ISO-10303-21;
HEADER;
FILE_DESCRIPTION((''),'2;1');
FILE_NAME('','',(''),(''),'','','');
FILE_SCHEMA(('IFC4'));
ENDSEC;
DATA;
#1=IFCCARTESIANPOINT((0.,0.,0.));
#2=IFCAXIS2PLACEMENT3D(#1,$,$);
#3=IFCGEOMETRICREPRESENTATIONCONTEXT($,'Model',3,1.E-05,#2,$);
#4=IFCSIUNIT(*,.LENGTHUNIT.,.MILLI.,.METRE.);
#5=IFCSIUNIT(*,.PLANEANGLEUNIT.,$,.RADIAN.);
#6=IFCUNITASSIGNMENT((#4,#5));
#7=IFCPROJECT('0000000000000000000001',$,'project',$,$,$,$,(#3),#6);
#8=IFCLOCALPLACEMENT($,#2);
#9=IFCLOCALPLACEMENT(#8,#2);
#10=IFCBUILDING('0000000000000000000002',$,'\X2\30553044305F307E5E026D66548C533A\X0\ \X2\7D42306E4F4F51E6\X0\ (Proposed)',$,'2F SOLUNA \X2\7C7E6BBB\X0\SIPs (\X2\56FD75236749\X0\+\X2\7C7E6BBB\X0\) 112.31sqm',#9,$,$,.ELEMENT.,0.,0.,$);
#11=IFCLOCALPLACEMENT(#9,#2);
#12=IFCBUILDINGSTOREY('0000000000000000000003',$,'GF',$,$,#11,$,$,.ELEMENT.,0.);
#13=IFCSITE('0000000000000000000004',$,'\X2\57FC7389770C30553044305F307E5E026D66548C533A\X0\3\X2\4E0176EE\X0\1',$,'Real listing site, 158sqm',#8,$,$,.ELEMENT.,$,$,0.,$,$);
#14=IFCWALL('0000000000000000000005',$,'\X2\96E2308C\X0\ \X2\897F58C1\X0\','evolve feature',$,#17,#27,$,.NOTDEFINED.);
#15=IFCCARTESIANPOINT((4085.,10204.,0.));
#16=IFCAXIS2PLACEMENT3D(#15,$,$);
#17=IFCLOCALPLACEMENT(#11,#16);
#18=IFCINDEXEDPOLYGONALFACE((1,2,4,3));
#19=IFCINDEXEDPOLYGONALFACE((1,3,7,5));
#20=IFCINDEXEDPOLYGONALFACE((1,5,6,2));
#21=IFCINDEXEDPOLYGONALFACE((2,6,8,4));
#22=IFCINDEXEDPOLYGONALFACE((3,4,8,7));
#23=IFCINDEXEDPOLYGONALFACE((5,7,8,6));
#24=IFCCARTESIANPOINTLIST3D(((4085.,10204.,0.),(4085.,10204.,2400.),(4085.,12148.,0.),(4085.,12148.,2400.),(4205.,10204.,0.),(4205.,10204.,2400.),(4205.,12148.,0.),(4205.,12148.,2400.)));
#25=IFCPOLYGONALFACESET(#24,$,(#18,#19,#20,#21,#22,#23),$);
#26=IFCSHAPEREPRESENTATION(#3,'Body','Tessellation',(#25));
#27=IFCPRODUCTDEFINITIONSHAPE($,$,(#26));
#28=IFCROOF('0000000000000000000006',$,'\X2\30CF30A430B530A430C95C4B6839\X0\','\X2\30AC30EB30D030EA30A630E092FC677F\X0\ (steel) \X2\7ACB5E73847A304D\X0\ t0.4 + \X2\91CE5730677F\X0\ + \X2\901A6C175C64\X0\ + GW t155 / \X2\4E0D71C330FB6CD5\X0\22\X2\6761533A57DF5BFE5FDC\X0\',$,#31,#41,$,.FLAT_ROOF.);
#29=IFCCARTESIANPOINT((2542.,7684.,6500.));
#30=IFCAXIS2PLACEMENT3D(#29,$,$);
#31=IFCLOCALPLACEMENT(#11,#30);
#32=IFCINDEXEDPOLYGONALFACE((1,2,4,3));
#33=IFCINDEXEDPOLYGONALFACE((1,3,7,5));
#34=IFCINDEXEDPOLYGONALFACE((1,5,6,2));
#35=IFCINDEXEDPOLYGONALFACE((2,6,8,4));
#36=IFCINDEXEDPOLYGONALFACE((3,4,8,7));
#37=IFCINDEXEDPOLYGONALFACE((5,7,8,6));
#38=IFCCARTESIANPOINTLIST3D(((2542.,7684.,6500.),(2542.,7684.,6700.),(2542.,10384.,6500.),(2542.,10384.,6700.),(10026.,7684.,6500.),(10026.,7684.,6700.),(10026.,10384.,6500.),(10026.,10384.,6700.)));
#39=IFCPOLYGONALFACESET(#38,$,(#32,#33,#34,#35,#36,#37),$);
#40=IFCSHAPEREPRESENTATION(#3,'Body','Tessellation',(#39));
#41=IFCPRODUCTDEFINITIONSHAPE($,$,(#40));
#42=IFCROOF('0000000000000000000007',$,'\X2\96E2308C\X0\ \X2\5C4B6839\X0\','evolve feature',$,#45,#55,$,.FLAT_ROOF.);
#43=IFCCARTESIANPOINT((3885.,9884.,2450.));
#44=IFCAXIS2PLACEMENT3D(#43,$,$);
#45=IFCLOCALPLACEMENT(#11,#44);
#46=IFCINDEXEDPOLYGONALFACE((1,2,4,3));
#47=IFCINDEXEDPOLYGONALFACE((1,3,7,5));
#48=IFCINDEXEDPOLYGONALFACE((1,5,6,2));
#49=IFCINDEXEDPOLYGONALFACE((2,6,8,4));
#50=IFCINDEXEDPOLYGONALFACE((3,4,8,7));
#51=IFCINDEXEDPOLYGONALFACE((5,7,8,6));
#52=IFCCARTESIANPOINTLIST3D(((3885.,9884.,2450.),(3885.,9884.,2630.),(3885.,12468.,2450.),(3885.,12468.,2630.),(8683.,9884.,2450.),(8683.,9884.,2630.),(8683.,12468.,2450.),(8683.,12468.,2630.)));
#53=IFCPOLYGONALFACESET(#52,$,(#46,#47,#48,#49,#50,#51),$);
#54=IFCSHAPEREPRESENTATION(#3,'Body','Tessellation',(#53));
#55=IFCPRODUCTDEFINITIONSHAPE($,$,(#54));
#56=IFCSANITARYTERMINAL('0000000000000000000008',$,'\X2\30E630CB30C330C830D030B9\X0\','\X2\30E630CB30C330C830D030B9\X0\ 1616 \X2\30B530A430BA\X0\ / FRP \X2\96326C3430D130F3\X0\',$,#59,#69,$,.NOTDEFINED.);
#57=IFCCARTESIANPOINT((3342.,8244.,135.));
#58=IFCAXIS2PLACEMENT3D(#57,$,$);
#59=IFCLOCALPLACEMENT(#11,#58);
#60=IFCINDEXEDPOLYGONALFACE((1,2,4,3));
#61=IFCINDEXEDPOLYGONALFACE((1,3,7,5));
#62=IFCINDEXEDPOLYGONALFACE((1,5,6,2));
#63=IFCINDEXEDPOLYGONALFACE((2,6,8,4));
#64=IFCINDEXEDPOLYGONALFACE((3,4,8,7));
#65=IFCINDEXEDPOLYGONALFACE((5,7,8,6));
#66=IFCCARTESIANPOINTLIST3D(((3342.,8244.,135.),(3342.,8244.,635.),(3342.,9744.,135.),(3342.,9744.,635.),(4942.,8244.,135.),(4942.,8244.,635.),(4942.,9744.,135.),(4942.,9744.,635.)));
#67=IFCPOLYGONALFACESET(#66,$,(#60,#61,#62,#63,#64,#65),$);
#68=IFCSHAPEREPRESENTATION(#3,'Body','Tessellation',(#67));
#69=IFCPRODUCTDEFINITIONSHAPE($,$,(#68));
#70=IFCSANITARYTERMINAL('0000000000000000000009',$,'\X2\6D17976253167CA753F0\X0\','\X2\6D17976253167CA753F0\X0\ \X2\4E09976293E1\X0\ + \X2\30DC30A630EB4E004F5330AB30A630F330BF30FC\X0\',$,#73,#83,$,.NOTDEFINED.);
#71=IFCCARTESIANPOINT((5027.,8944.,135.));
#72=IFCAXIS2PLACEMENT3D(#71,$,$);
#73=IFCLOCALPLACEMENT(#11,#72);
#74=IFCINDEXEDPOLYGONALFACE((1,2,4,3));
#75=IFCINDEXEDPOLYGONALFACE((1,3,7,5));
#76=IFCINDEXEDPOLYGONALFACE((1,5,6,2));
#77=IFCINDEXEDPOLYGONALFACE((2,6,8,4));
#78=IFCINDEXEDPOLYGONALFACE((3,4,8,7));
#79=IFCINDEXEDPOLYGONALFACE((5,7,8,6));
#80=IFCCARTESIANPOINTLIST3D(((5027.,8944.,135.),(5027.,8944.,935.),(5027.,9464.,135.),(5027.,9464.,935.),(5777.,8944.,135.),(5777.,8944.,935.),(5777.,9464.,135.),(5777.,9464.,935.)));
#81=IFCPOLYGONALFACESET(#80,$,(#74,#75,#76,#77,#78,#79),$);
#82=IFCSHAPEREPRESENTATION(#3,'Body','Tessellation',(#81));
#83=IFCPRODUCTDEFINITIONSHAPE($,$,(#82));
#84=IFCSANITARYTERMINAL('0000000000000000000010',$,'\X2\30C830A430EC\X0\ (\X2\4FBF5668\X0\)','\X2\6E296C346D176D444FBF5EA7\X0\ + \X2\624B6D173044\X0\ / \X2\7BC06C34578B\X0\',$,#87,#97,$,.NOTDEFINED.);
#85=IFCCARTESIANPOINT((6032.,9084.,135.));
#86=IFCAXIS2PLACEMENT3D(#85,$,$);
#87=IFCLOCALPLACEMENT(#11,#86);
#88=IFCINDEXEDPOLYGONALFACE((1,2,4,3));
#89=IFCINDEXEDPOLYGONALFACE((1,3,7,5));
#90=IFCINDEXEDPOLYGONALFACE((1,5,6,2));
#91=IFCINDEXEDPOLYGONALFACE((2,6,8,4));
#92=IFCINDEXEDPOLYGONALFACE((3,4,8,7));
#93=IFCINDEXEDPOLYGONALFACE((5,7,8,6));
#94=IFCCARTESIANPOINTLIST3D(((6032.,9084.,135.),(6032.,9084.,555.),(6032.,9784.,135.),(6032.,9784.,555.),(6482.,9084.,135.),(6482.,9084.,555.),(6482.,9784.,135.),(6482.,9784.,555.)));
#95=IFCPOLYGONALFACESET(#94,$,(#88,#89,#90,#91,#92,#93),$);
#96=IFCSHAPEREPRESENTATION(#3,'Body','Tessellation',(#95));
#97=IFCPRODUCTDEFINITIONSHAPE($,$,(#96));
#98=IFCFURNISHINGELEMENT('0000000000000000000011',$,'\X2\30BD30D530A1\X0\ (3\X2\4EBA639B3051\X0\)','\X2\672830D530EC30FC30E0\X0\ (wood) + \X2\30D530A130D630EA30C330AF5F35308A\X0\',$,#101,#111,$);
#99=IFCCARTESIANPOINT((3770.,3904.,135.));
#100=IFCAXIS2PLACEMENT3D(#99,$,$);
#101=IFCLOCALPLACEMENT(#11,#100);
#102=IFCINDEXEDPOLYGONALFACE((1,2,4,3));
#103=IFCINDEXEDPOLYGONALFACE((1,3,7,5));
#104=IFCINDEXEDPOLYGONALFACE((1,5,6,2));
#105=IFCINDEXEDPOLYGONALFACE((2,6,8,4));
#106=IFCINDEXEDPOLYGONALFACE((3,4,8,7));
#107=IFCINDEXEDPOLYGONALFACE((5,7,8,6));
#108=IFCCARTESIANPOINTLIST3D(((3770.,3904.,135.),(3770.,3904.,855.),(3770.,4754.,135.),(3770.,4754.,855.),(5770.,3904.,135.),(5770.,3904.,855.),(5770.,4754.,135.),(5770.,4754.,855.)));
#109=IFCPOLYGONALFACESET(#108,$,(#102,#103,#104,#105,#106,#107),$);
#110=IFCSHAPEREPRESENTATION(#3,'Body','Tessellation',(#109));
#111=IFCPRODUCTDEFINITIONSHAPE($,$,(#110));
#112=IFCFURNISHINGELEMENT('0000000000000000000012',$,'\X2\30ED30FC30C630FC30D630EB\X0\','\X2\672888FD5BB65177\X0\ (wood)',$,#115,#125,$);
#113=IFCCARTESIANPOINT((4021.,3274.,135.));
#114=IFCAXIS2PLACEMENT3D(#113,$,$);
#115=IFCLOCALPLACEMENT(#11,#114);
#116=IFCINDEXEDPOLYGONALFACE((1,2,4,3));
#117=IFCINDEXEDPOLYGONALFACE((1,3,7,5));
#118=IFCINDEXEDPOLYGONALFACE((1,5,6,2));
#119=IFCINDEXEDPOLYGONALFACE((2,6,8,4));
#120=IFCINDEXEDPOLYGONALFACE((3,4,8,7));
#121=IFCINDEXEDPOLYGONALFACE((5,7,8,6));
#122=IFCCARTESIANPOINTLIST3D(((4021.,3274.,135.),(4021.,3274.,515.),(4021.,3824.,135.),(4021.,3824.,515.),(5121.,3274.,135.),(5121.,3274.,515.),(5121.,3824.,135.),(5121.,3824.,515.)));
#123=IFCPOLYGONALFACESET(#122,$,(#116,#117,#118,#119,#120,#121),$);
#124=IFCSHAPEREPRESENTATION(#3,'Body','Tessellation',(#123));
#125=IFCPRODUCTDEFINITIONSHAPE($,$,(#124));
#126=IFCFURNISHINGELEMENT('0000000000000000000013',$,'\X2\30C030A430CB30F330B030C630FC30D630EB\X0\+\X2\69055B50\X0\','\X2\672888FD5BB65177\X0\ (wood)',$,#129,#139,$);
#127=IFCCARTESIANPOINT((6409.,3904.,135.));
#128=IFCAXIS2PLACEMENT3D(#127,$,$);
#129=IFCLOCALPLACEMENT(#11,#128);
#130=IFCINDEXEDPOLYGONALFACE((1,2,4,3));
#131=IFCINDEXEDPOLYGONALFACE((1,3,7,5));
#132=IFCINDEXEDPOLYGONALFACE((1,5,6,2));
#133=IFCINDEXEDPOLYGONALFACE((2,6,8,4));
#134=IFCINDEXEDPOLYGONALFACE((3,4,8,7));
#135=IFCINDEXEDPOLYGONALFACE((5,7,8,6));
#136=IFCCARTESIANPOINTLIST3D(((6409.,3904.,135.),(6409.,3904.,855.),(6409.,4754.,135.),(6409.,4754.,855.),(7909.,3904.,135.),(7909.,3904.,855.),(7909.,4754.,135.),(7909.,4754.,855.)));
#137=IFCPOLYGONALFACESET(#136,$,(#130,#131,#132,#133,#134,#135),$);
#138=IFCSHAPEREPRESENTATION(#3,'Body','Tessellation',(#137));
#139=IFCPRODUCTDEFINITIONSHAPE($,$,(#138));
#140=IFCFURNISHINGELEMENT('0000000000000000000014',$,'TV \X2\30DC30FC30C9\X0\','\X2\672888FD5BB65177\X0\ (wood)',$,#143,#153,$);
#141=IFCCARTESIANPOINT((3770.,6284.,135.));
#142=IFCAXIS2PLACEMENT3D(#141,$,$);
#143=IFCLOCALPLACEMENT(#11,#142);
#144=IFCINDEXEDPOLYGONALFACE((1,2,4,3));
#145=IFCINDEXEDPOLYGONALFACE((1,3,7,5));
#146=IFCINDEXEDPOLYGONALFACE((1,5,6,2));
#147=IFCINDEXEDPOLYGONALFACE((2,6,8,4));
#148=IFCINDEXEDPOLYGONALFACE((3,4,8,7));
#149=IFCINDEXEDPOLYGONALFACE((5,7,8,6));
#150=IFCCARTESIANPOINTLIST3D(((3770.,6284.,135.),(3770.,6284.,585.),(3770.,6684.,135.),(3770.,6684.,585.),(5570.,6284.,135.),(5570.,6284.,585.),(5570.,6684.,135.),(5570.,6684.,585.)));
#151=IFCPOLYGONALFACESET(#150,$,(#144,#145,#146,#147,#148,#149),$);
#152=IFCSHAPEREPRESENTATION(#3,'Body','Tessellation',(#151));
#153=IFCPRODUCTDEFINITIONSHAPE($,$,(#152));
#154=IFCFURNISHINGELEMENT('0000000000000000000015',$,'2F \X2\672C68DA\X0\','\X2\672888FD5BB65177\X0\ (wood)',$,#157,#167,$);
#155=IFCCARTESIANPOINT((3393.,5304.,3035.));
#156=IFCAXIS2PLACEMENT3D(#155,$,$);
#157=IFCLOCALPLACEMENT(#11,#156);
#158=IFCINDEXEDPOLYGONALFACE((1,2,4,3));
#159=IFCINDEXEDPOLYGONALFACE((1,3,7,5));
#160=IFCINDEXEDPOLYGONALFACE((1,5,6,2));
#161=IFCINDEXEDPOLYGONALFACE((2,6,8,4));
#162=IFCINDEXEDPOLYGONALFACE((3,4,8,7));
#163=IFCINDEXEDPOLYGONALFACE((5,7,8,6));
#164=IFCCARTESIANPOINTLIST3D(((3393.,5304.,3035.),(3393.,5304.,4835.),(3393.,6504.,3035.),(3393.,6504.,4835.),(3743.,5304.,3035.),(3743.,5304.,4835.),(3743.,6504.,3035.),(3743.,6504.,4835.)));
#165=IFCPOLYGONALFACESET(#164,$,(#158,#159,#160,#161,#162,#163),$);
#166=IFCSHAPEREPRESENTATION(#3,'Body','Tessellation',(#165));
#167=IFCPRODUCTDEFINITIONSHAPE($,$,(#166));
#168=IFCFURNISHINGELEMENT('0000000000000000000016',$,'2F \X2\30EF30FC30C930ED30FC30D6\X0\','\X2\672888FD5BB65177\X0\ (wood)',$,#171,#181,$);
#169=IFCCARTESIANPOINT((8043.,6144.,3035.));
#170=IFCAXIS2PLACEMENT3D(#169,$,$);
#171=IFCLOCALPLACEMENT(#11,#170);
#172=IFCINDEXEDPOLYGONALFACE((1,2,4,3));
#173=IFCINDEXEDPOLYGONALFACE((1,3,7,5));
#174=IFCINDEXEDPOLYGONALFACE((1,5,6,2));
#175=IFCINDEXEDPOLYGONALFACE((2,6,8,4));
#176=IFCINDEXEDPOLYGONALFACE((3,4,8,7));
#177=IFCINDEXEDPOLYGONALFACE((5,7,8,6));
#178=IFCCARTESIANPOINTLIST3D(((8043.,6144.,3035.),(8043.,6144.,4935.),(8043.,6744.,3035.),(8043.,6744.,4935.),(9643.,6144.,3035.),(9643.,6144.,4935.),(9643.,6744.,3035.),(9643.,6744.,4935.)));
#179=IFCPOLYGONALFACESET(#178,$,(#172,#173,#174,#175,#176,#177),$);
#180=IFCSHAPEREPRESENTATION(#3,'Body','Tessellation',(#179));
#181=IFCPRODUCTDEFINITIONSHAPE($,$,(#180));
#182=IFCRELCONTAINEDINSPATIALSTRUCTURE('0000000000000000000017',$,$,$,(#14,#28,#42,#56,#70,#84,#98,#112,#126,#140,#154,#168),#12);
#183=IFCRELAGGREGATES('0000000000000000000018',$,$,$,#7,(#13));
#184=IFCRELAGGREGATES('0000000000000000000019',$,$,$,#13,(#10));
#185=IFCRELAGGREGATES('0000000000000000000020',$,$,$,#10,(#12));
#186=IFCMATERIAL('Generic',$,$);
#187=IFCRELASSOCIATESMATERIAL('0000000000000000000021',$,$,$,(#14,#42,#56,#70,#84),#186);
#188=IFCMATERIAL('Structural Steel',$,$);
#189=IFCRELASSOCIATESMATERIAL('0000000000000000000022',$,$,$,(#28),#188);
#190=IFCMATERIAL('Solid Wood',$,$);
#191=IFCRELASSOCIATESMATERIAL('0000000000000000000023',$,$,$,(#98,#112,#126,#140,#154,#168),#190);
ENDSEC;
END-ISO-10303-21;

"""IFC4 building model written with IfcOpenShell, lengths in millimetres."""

from ifc_helpers import new_model, si_unit, frame, frame_2d, origin, place, context, project, spatial, rectangle, extrude, material, element, save


model = new_model("IFC4")

# Units and contexts
model_context = context("Model", 3, precision=1e-05, world=origin())
ifc_project = project(units=[si_unit("LENGTHUNIT", "METRE", prefix="MILLI"), si_unit("PLANEANGLEUNIT", "RADIAN")], contexts=[model_context])

# Site, building, storey
site_placement = place(None, origin())
site = spatial("IfcSite", under=ifc_project, at=site_placement, Name="埼玉県さいたま市浦和区3丁目1", ObjectType="Real listing site, 158sqm", CompositionType="ELEMENT", RefElevation=0.0)
building_placement = place(site_placement, origin())
building = spatial("IfcBuilding", under=site, at=building_placement, Name="さいたま市浦和区 終の住処 (Proposed)", ObjectType="2F SOLUNA 籾殻SIPs (国産杉+籾殻) 112.31sqm", CompositionType="ELEMENT", ElevationOfRefHeight=0.0, ElevationOfTerrain=0.0)
storey_placement = place(building_placement, origin())
storey = spatial("IfcBuildingStorey", under=building, at=storey_placement, Name="GF", CompositionType="ELEMENT", Elevation=0.0)

# Shared definitions
ifc_material_1 = material(Name="Generic")

# Shared definitions
ifc_material_2 = material(Name="Solid Wood")

# Wall
wall_1_placement = place(storey_placement, frame((4085.0, 10204.0, 0.0)))
element("IfcWall", 1, at=wall_1_placement, inside=storey, material=ifc_material_1, Name="離れ 西壁", Description="evolve feature", PredefinedType="NOTDEFINED", context=model_context, shape_type="SweptSolid", body=[
    extrude(rectangle(XDim=120.0, YDim=1944.0, at=frame_2d((60.0, 972.0))), frame((4085.0, 10204.0, 0.0)), (0.0, 0.0, 1.0), 2400.0),
])

# Roofs
ifc_material_3 = material(Name="Structural Steel")
roof_1_placement = place(storey_placement, frame((2542.0, 7684.0, 6500.0)))
element("IfcRoof", 2, at=roof_1_placement, inside=storey, material=ifc_material_3, Name="ハイサイド屋根", Description="ガルバリウム鋼板 (steel) 立平葺き t0.4 + 野地板 + 通気層 + GW t155 / 不燃・法22条区域対応", PredefinedType="FLAT_ROOF", context=model_context, shape_type="SweptSolid", body=[
    extrude(rectangle(XDim=7484.0, YDim=2700.0, at=frame_2d((3742.0, 1350.0))), frame((2542.0, 7684.0, 6500.0)), (0.0, 0.0, 1.0), 200.0),
])
roof_2_placement = place(storey_placement, frame((3885.0, 9884.0, 2450.0)))
element("IfcRoof", 3, at=roof_2_placement, inside=storey, material=ifc_material_1, Name="離れ 屋根", Description="evolve feature", PredefinedType="FLAT_ROOF", context=model_context, shape_type="SweptSolid", body=[
    extrude(rectangle(XDim=4798.0, YDim=2584.0, at=frame_2d((2399.0, 1292.0))), frame((3885.0, 9884.0, 2450.0)), (0.0, 0.0, 1.0), 180.0),
])

# Sanitary terminals
sanitary_terminal_1_placement = place(storey_placement, frame((3342.0, 8244.0, 135.0)))
element("IfcSanitaryTerminal", 4, at=sanitary_terminal_1_placement, inside=storey, material=ifc_material_1, Name="ユニットバス", Description="ユニットバス 1616 サイズ / FRP 防水パン", PredefinedType="NOTDEFINED", context=model_context, shape_type="SweptSolid", body=[
    extrude(rectangle(XDim=1600.0, YDim=1500.0, at=frame_2d((800.0, 750.0))), frame((3342.0, 8244.0, 135.0)), (0.0, 0.0, 1.0), 500.0),
])
sanitary_terminal_2_placement = place(storey_placement, frame((5027.0, 8944.0, 135.0)))
element("IfcSanitaryTerminal", 5, at=sanitary_terminal_2_placement, inside=storey, material=ifc_material_1, Name="洗面化粧台", Description="洗面化粧台 三面鏡 + ボウル一体カウンター", PredefinedType="NOTDEFINED", context=model_context, shape_type="SweptSolid", body=[
    extrude(rectangle(XDim=750.0, YDim=520.0, at=frame_2d((375.0, 260.0))), frame((5027.0, 8944.0, 135.0)), (0.0, 0.0, 1.0), 800.0),
])
sanitary_terminal_3_placement = place(storey_placement, frame((6032.0, 9084.0, 135.0)))
element("IfcSanitaryTerminal", 6, at=sanitary_terminal_3_placement, inside=storey, material=ifc_material_1, Name="トイレ (便器)", Description="温水洗浄便座 + 手洗い / 節水型", PredefinedType="NOTDEFINED", context=model_context, shape_type="SweptSolid", body=[
    extrude(rectangle(XDim=450.0, YDim=700.0, at=frame_2d((225.0, 350.0))), frame((6032.0, 9084.0, 135.0)), (0.0, 0.0, 1.0), 420.0),
])

# Furnishing elements
furnishing_1_placement = place(storey_placement, frame((3770.0, 3904.0, 135.0)))
element("IfcFurnishingElement", 7, at=furnishing_1_placement, inside=storey, material=ifc_material_2, Name="ソファ (3人掛け)", Description="木フレーム (wood) + ファブリック張り", context=model_context, shape_type="SweptSolid", body=[
    extrude(rectangle(XDim=2000.0, YDim=850.0, at=frame_2d((1000.0, 425.0))), frame((3770.0, 3904.0, 135.0)), (0.0, 0.0, 1.0), 720.0),
])
furnishing_2_placement = place(storey_placement, frame((4021.0, 3274.0, 135.0)))
element("IfcFurnishingElement", 8, at=furnishing_2_placement, inside=storey, material=ifc_material_2, Name="ローテーブル", Description="木製家具 (wood)", context=model_context, shape_type="SweptSolid", body=[
    extrude(rectangle(XDim=1100.0, YDim=550.0, at=frame_2d((550.0, 275.0))), frame((4021.0, 3274.0, 135.0)), (0.0, 0.0, 1.0), 380.0),
])
furnishing_3_placement = place(storey_placement, frame((6409.0, 3904.0, 135.0)))
element("IfcFurnishingElement", 9, at=furnishing_3_placement, inside=storey, material=ifc_material_2, Name="ダイニングテーブル+椅子", Description="木製家具 (wood)", context=model_context, shape_type="SweptSolid", body=[
    extrude(rectangle(XDim=1500.0, YDim=850.0, at=frame_2d((750.0, 425.0))), frame((6409.0, 3904.0, 135.0)), (0.0, 0.0, 1.0), 720.0),
])
furnishing_4_placement = place(storey_placement, frame((3770.0, 6284.0, 135.0)))
element("IfcFurnishingElement", 10, at=furnishing_4_placement, inside=storey, material=ifc_material_2, Name="TV ボード", Description="木製家具 (wood)", context=model_context, shape_type="SweptSolid", body=[
    extrude(rectangle(XDim=1800.0, YDim=400.0, at=frame_2d((900.0, 200.0))), frame((3770.0, 6284.0, 135.0)), (0.0, 0.0, 1.0), 450.0),
])
furnishing_5_placement = place(storey_placement, frame((3393.0, 5304.0, 3035.0)))
element("IfcFurnishingElement", 11, at=furnishing_5_placement, inside=storey, material=ifc_material_2, Name="2F 本棚", Description="木製家具 (wood)", context=model_context, shape_type="SweptSolid", body=[
    extrude(rectangle(XDim=350.0, YDim=1200.0, at=frame_2d((175.0, 600.0))), frame((3393.0, 5304.0, 3035.0)), (0.0, 0.0, 1.0), 1800.0),
])
furnishing_6_placement = place(storey_placement, frame((8043.0, 6144.0, 3035.0)))
element("IfcFurnishingElement", 12, at=furnishing_6_placement, inside=storey, material=ifc_material_2, Name="2F ワードローブ", Description="木製家具 (wood)", context=model_context, shape_type="SweptSolid", body=[
    extrude(rectangle(XDim=1600.0, YDim=600.0, at=frame_2d((800.0, 300.0))), frame((8043.0, 6144.0, 3035.0)), (0.0, 0.0, 1.0), 1900.0),
])

save(model, "model.ifc")
